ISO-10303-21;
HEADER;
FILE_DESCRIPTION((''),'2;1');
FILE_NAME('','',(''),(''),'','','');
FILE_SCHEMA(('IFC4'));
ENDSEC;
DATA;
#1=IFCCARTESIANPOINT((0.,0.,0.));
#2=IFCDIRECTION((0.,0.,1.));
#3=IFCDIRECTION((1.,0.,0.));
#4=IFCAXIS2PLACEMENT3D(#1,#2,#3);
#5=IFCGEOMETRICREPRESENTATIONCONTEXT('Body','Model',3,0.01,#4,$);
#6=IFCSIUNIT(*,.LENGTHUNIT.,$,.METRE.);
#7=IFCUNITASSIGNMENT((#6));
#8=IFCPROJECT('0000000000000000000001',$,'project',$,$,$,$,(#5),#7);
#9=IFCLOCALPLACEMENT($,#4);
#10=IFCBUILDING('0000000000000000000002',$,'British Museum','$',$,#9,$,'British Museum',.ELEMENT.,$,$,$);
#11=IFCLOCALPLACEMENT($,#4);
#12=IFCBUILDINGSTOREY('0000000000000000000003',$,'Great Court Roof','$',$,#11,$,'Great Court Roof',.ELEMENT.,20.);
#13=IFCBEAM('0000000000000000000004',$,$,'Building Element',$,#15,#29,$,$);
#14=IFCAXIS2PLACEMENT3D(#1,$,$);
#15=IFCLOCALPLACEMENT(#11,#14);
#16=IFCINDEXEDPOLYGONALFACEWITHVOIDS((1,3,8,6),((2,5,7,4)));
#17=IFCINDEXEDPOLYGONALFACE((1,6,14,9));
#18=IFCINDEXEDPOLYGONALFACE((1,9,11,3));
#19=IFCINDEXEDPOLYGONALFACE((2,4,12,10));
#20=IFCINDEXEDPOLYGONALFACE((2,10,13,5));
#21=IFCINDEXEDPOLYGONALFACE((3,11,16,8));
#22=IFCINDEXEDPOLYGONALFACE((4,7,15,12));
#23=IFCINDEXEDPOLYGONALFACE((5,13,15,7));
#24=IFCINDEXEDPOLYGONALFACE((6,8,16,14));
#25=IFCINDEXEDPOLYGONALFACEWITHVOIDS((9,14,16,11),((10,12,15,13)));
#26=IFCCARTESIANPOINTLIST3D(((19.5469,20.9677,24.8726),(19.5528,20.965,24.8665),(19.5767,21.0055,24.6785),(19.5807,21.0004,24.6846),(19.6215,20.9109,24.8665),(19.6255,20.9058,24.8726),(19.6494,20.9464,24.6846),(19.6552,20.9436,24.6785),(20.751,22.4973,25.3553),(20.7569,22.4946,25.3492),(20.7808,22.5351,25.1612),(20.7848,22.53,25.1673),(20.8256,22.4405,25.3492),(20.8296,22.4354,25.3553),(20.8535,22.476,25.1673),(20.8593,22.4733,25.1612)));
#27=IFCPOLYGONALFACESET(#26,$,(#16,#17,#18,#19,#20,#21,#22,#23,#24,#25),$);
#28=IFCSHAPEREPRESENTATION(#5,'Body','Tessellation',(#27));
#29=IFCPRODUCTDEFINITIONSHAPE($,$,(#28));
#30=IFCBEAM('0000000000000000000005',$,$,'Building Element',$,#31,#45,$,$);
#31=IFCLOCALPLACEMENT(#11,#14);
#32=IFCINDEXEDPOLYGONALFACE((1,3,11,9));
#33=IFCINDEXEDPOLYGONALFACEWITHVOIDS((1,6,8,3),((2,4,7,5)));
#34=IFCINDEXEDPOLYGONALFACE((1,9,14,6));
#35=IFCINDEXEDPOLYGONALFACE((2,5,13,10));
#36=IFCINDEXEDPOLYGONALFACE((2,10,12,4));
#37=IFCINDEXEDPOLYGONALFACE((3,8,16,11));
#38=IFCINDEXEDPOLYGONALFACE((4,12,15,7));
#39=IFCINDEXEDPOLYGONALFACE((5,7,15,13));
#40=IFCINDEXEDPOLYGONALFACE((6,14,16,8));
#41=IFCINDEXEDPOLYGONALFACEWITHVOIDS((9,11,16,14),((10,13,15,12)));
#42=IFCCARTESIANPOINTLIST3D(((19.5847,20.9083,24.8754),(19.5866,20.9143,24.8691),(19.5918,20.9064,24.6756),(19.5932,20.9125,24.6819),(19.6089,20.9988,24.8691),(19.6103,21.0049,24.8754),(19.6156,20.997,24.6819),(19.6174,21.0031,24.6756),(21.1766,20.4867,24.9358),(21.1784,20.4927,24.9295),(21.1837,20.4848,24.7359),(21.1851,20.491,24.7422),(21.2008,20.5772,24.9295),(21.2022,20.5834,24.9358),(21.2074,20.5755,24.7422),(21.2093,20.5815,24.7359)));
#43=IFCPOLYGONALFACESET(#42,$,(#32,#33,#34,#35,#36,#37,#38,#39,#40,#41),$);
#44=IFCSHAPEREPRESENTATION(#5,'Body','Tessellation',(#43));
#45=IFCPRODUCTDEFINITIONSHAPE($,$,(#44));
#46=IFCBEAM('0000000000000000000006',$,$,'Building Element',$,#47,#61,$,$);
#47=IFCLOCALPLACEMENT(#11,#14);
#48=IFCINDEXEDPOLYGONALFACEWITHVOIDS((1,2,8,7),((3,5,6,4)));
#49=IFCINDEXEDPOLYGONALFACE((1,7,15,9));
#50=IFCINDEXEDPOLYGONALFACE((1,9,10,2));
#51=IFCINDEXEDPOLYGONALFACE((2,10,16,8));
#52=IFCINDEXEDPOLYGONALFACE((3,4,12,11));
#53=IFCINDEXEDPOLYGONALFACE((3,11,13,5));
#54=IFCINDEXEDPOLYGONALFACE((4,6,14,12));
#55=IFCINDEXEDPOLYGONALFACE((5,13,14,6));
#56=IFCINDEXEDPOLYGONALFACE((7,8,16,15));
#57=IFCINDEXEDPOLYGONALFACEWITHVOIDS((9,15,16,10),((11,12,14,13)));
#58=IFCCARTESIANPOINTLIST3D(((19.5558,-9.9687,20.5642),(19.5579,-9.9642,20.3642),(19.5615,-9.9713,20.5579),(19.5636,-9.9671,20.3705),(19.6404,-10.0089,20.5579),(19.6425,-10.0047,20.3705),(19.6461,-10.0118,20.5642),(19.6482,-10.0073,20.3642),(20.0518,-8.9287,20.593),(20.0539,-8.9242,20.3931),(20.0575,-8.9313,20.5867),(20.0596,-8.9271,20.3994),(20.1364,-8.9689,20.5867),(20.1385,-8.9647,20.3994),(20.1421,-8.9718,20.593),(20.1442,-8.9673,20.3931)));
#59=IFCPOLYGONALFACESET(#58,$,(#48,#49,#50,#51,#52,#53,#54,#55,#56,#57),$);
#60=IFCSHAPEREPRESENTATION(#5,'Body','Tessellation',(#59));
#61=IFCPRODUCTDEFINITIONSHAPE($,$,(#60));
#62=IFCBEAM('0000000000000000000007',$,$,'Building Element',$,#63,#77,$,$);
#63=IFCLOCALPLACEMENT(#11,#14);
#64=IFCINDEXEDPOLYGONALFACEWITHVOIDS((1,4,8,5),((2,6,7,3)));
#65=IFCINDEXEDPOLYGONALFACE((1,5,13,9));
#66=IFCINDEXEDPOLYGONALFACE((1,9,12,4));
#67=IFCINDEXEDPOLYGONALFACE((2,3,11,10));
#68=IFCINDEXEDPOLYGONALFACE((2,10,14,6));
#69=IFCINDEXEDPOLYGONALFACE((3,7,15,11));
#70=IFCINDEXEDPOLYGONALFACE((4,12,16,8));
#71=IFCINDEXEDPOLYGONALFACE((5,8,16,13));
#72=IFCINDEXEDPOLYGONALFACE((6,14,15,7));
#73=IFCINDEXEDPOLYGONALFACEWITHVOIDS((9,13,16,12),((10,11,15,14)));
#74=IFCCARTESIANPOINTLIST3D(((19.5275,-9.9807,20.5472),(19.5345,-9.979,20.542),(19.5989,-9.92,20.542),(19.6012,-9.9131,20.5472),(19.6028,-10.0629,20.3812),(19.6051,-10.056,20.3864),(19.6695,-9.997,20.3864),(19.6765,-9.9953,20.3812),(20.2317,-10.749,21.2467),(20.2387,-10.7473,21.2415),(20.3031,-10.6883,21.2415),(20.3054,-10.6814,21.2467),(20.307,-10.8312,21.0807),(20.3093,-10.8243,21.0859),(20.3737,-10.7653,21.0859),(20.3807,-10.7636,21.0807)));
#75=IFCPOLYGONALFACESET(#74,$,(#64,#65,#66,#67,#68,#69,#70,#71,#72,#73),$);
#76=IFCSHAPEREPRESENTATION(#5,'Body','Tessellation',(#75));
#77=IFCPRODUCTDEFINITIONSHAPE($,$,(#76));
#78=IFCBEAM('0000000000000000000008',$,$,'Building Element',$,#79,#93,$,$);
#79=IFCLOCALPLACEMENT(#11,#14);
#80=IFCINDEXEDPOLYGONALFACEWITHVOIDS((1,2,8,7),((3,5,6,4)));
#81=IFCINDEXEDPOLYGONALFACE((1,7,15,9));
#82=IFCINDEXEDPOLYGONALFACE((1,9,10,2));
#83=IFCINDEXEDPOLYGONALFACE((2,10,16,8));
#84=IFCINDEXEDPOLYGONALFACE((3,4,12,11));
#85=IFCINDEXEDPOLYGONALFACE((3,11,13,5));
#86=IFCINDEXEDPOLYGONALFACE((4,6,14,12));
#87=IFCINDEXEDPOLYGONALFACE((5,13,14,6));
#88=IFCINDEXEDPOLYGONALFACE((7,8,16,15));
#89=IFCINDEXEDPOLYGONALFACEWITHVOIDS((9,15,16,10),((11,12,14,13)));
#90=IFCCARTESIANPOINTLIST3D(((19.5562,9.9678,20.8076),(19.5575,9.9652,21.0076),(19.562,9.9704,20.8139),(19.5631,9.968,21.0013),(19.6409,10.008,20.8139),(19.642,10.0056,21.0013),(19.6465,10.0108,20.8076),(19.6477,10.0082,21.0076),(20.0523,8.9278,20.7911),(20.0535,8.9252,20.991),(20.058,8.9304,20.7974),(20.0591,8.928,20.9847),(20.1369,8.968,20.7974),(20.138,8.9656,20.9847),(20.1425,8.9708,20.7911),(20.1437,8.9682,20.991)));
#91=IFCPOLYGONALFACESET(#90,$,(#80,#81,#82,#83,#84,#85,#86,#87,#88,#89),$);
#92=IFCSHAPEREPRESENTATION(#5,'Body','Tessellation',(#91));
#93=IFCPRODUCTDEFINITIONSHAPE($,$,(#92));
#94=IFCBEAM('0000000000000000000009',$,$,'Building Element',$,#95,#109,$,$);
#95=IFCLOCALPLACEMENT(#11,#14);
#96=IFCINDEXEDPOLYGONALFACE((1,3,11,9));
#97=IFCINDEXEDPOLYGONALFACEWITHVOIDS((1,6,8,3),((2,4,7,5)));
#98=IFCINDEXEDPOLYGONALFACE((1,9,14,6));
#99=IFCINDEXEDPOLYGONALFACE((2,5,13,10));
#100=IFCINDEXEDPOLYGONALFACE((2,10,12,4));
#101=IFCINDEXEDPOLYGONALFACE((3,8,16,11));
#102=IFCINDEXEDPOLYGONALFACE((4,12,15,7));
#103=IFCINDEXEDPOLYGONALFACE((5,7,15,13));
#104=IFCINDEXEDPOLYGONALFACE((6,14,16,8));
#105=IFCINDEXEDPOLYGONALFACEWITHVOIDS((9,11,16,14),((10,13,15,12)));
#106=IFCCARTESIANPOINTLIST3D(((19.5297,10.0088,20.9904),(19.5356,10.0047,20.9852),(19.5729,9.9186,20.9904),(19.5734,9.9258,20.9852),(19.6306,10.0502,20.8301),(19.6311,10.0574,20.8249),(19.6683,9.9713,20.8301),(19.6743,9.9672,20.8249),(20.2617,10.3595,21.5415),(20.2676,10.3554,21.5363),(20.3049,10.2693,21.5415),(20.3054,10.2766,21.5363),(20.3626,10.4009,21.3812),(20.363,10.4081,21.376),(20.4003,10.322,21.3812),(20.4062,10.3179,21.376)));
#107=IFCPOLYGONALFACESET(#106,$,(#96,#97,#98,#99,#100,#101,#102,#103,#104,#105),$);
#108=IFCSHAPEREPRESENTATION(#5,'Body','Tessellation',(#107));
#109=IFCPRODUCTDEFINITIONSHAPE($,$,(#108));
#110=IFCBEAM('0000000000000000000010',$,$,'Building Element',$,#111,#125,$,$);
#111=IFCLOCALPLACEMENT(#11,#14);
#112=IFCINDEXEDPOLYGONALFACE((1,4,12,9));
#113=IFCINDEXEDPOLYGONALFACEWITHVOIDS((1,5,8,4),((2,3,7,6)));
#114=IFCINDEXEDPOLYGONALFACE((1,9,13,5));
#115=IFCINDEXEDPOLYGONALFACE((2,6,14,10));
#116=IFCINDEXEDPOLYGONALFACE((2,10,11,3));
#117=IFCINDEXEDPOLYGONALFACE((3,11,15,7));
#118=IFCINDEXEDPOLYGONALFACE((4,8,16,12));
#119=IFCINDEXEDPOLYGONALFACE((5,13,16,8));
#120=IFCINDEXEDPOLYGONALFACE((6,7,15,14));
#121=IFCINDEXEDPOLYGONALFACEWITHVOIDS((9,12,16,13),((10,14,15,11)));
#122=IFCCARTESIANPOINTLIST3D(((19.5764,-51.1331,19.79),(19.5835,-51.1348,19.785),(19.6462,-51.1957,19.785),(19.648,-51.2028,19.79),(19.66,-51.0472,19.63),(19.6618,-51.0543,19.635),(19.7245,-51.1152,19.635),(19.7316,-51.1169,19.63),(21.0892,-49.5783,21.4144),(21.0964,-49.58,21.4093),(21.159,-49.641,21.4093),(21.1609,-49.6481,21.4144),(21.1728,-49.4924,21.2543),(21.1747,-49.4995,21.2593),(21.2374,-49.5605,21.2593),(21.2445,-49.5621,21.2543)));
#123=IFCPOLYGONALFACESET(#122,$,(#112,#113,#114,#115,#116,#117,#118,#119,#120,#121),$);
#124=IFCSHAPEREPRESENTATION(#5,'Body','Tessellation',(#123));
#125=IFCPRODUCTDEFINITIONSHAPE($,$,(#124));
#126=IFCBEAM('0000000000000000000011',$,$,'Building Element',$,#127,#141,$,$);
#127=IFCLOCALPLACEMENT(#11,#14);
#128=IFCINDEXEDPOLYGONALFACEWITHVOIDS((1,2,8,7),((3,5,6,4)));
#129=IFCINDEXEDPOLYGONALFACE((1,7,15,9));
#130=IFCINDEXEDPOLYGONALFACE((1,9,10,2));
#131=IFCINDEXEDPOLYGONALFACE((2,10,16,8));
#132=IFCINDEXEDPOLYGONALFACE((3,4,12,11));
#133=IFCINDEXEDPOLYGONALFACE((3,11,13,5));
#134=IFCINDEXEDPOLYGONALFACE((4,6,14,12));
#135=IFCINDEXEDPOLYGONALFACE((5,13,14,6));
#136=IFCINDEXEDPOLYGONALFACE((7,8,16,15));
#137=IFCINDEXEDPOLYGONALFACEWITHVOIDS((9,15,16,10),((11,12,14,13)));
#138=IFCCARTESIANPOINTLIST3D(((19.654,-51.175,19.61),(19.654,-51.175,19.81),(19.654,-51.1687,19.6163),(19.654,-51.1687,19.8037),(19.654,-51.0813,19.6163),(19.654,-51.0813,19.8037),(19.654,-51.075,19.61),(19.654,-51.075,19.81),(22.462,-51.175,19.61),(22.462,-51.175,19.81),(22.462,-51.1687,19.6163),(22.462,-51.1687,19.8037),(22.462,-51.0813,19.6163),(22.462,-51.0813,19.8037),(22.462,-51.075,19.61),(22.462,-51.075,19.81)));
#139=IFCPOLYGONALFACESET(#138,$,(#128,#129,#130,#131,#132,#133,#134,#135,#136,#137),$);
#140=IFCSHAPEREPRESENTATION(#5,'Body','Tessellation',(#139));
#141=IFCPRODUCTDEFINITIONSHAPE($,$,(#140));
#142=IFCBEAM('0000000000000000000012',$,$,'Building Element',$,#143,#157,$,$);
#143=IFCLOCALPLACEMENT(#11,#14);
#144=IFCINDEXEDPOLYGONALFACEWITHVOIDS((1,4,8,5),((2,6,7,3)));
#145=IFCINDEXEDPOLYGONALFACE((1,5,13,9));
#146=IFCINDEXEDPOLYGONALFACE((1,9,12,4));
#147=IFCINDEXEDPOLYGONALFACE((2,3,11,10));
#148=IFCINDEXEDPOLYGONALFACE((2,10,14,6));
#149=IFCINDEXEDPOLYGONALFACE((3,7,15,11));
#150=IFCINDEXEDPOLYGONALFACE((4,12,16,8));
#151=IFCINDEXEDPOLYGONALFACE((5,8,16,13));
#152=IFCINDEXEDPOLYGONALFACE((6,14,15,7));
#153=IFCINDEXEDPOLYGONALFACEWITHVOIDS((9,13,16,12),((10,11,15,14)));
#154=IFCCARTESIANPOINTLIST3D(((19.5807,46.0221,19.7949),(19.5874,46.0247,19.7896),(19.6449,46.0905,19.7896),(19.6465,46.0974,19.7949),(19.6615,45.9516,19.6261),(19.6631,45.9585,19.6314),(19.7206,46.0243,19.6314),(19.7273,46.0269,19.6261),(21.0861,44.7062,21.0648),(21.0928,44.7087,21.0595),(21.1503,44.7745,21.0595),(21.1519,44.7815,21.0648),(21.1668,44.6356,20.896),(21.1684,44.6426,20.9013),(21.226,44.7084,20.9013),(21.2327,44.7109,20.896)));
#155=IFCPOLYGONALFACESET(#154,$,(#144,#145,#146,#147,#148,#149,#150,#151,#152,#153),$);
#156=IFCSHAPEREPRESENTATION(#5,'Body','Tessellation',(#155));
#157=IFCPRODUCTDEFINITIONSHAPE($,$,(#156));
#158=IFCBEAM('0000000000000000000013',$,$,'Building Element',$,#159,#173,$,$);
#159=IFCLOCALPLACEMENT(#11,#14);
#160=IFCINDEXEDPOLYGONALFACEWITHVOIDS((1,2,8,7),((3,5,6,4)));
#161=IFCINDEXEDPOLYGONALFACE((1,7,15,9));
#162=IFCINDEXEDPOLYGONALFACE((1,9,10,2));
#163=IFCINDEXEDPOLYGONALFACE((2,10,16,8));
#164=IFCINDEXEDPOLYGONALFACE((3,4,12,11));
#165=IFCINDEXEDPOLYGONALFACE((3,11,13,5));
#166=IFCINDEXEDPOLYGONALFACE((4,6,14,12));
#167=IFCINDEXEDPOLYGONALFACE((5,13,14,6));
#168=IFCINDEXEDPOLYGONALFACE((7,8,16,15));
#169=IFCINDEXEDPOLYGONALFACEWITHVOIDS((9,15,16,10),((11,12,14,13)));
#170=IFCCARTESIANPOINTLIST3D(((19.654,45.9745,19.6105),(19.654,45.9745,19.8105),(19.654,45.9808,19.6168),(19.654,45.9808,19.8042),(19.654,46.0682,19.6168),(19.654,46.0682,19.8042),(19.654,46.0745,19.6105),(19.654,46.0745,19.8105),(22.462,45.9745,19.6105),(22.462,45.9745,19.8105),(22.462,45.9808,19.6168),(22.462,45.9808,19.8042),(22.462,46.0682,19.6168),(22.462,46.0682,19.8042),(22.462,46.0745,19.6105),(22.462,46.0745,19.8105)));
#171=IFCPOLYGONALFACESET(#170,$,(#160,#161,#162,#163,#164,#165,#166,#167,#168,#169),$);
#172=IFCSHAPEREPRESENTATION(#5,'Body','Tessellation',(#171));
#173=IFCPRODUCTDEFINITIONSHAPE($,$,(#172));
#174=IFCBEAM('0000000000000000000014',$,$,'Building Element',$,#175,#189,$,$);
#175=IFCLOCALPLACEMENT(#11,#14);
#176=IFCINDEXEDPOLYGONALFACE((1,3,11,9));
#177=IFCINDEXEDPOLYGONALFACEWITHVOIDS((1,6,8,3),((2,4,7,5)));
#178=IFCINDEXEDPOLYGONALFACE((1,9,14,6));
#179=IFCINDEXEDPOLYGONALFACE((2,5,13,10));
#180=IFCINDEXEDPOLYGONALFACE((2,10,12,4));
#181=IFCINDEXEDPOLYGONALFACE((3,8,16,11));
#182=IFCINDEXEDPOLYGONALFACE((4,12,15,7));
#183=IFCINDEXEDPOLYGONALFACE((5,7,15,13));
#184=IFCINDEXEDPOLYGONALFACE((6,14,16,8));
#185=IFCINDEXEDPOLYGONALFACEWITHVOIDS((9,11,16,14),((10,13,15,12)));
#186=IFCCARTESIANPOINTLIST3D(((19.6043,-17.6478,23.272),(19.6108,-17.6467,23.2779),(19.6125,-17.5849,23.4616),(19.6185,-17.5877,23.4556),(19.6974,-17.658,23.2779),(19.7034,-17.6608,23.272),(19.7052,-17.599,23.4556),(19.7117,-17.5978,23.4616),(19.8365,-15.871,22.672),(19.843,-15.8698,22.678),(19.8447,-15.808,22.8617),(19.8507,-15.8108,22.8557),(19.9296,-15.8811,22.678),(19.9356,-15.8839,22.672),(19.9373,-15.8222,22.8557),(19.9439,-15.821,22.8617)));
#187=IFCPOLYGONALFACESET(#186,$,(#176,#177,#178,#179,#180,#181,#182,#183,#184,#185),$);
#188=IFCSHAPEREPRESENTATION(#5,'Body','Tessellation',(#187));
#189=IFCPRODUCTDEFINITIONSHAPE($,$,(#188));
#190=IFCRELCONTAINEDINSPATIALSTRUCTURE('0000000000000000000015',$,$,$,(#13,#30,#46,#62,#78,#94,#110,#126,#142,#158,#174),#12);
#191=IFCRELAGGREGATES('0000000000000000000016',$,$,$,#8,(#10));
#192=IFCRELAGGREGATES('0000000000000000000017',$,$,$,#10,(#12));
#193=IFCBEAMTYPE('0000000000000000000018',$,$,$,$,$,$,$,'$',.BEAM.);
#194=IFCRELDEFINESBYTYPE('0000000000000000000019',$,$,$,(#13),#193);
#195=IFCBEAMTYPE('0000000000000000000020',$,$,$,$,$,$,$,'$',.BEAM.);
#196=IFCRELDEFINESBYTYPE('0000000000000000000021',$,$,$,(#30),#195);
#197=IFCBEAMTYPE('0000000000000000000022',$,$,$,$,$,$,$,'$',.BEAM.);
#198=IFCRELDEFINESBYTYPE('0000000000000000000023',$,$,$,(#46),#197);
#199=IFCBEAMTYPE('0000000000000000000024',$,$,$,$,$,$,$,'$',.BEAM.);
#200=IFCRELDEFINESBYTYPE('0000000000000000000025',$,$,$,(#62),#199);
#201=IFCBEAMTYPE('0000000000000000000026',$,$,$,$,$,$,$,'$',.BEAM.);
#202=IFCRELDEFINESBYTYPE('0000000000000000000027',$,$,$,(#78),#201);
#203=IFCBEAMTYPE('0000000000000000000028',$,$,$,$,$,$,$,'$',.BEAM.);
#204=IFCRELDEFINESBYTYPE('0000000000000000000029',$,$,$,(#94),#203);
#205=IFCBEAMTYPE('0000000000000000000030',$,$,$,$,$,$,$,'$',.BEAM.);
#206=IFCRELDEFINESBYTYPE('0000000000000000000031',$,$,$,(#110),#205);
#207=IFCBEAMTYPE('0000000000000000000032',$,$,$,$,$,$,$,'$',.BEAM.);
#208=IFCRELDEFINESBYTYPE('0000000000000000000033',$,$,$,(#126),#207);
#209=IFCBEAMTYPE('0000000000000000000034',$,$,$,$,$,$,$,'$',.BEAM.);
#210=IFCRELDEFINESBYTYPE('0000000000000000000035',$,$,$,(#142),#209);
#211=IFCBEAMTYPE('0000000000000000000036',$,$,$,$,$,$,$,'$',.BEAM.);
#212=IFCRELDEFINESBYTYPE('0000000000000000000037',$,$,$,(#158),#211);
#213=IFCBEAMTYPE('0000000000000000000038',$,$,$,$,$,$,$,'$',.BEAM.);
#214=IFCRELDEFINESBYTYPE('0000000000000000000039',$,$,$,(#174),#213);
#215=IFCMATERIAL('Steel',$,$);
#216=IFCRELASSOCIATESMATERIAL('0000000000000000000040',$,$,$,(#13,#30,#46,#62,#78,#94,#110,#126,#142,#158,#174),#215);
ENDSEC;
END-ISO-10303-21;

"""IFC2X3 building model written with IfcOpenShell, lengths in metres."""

from ifc_helpers import new_model, si_unit, frame, origin_with_axes, origin_2d, place, context, project, spatial, hollow_rectangle, extrude, material, type_object, element, save


model = new_model("IFC2X3")

# Units and contexts
model_context = context("Model", 3, precision=0.01, world=origin_with_axes(), identifier="Body")
ifc_project = project(units=[si_unit("LENGTHUNIT", "METRE")], contexts=[model_context])

# Building, storey
building_placement = place(None, origin_with_axes())
building = spatial("IfcBuilding", under=ifc_project, at=building_placement, Name="British Museum", Description="$", LongName="British Museum", CompositionType="ELEMENT")
storey_placement = place(None, origin_with_axes())
storey = spatial("IfcBuildingStorey", under=building, at=storey_placement, Name="Great Court Roof", Description="$", LongName="Great Court Roof", CompositionType="ELEMENT", Elevation=20.0)

# Beams
ifc_material = material(Name="Steel")
beam_type_1 = type_object("IfcBeamType", ElementType="$", PredefinedType="BEAM")
beam_1_placement = place(None, origin_with_axes())
element("IfcBeam", 1, at=beam_1_placement, inside=storey, type_object=beam_type_1, material=ifc_material, Description="Building Element", context=model_context, shape_type="SweptSolid", body=[
    extrude(hollow_rectangle(XDim=0.1, YDim=0.2, WallThickness=0.0063, InnerFilletRadius=-0.0063, OuterFilletRadius=0.0, at=origin_2d()), frame((19.6011, 20.9557, 24.7755), z_axis=(0.600352, 0.762651, 0.240707), x_axis=(-0.785754, 0.618539, 0.0)), (0.0, 0.0, 1.0), 2.0057),
])
beam_type_2 = type_object("IfcBeamType", ElementType="$", PredefinedType="BEAM")
beam_2_placement = place(None, origin_with_axes())
element("IfcBeam", 2, at=beam_2_placement, inside=storey, type_object=beam_type_2, material=ifc_material, Description="Building Element", context=model_context, shape_type="SweptSolid", body=[
    extrude(hollow_rectangle(XDim=0.1, YDim=0.2, WallThickness=0.0063, InnerFilletRadius=-0.0063, OuterFilletRadius=0.0, at=origin_2d()), frame((19.6011, 20.9557, 24.7755), z_axis=(0.966028, -0.255827, 0.036635), x_axis=(0.255999, 0.966677, 0.0)), (0.0, 0.0, 1.0), 1.6478),
])
beam_type_3 = type_object("IfcBeamType", ElementType="$", PredefinedType="BEAM")
beam_3_placement = place(None, origin_with_axes())
element("IfcBeam", 3, at=beam_3_placement, inside=storey, type_object=beam_type_3, material=ifc_material, Description="Building Element", context=model_context, shape_type="SweptSolid", body=[
    extrude(hollow_rectangle(XDim=0.1, YDim=0.2, WallThickness=0.0063, InnerFilletRadius=-0.0063, OuterFilletRadius=0.0, at=origin_2d()), frame((19.602, -9.988, 20.4642), z_axis=(0.430339, 0.902321, 0.025007), x_axis=(-0.902603, 0.430473, 0.0)), (0.0, 0.0, 1.0), 1.1526),
])
beam_type_4 = type_object("IfcBeamType", ElementType="$", PredefinedType="BEAM")
beam_4_placement = place(None, origin_with_axes())
element("IfcBeam", 4, at=beam_4_placement, inside=storey, type_object=beam_type_4, material=ifc_material, Description="Building Element", context=model_context, shape_type="SweptSolid", body=[
    extrude(hollow_rectangle(XDim=0.1, YDim=0.2, WallThickness=0.0063, InnerFilletRadius=-0.0063, OuterFilletRadius=0.0, at=origin_2d()), frame((19.602, -9.988, 20.4642), z_axis=(0.561035, -0.6121, 0.557291), x_axis=(0.737188, 0.675688, 0.0)), (0.0, 0.0, 1.0), 1.2552),
])
beam_type_5 = type_object("IfcBeamType", ElementType="$", PredefinedType="BEAM")
beam_5_placement = place(None, origin_with_axes())
element("IfcBeam", 5, at=beam_5_placement, inside=storey, type_object=beam_type_5, material=ifc_material, Description="Building Element", context=model_context, shape_type="SweptSolid", body=[
    extrude(hollow_rectangle(XDim=0.1, YDim=0.2, WallThickness=0.0063, InnerFilletRadius=-0.0063, OuterFilletRadius=0.0, at=origin_2d()), frame((19.602, 9.988, 20.9076), z_axis=(0.430429, -0.90251, -0.014389), x_axis=(0.902603, 0.430473, 0.0)), (0.0, 0.0, 1.0), 1.1523),
])
beam_type_6 = type_object("IfcBeamType", ElementType="$", PredefinedType="BEAM")
beam_6_placement = place(None, origin_with_axes())
element("IfcBeam", 6, at=beam_6_placement, inside=storey, type_object=beam_type_6, material=ifc_material, Description="Building Element", context=model_context, shape_type="SweptSolid", body=[
    extrude(hollow_rectangle(XDim=0.1, YDim=0.2, WallThickness=0.0063, InnerFilletRadius=-0.0063, OuterFilletRadius=0.0, at=origin_2d()), frame((19.602, 9.988, 20.9076), z_axis=(0.746098, 0.357478, 0.561736), x_axis=(-0.432094, 0.901829, 0.0)), (0.0, 0.0, 1.0), 0.9811),
])
beam_type_7 = type_object("IfcBeamType", ElementType="$", PredefinedType="BEAM")
beam_7_placement = place(None, origin_with_axes())
element("IfcBeam", 7, at=beam_7_placement, inside=storey, type_object=beam_type_7, material=ifc_material, Description="Building Element", context=model_context, shape_type="SweptSolid", body=[
    extrude(hollow_rectangle(XDim=0.1, YDim=0.2, WallThickness=0.0063, InnerFilletRadius=-0.0063, OuterFilletRadius=0.0, at=origin_2d()), frame((19.654, -51.125, 19.71), z_axis=(0.558244, 0.573698, 0.599361), x_axis=(-0.716694, 0.697388, 0.0)), (0.0, 0.0, 1.0), 2.7101),
])
beam_type_8 = type_object("IfcBeamType", ElementType="$", PredefinedType="BEAM")
beam_8_placement = place(None, origin_with_axes())
element("IfcBeam", 8, at=beam_8_placement, inside=storey, type_object=beam_type_8, material=ifc_material, Description="Building Element", context=model_context, shape_type="SweptSolid", body=[
    extrude(hollow_rectangle(XDim=0.1, YDim=0.2, WallThickness=0.0063, InnerFilletRadius=-0.0063, OuterFilletRadius=0.0, at=origin_2d()), frame((19.654, -51.125, 19.71), z_axis=(1.0, 0.0, 0.0), x_axis=(0.0, 1.0, 0.0)), (0.0, 0.0, 1.0), 2.808),
])
beam_type_9 = type_object("IfcBeamType", ElementType="$", PredefinedType="BEAM")
beam_9_placement = place(None, origin_with_axes())
element("IfcBeam", 9, at=beam_9_placement, inside=storey, type_object=beam_type_9, material=ifc_material, Description="Building Element", context=model_context, shape_type="SweptSolid", body=[
    extrude(hollow_rectangle(XDim=0.1, YDim=0.2, WallThickness=0.0063, InnerFilletRadius=-0.0063, OuterFilletRadius=0.0, at=origin_2d()), frame((19.654, 46.0245, 19.7105), z_axis=(0.635544, -0.55556, 0.536132), x_axis=(0.658142, 0.752894, 0.0)), (0.0, 0.0, 1.0), 2.3686),
])
beam_type_10 = type_object("IfcBeamType", ElementType="$", PredefinedType="BEAM")
beam_10_placement = place(None, origin_with_axes())
element("IfcBeam", 10, at=beam_10_placement, inside=storey, type_object=beam_type_10, material=ifc_material, Description="Building Element", context=model_context, shape_type="SweptSolid", body=[
    extrude(hollow_rectangle(XDim=0.1, YDim=0.2, WallThickness=0.0063, InnerFilletRadius=-0.0063, OuterFilletRadius=0.0, at=origin_2d()), frame((19.654, 46.0245, 19.7105), z_axis=(1.0, 0.0, -0.000011), x_axis=(0.0, 1.0, 0.0)), (0.0, 0.0, 1.0), 2.808),
])
beam_type_11 = type_object("IfcBeamType", ElementType="$", PredefinedType="BEAM")
beam_11_placement = place(None, origin_with_axes())
element("IfcBeam", 11, at=beam_11_placement, inside=storey, type_object=beam_type_11, material=ifc_material, Description="Building Element", context=model_context, shape_type="SweptSolid", body=[
    extrude(hollow_rectangle(XDim=0.1, YDim=0.2, WallThickness=0.0063, InnerFilletRadius=-0.0063, OuterFilletRadius=0.0, at=origin_2d()), frame((19.658, -17.6228, 23.3668), z_axis=(0.122873, 0.940273, -0.317472), x_axis=(-0.991569, 0.129577, 0.0)), (0.0, 0.0, 1.0), 1.8897),
])

save(model, "model.ifc")
